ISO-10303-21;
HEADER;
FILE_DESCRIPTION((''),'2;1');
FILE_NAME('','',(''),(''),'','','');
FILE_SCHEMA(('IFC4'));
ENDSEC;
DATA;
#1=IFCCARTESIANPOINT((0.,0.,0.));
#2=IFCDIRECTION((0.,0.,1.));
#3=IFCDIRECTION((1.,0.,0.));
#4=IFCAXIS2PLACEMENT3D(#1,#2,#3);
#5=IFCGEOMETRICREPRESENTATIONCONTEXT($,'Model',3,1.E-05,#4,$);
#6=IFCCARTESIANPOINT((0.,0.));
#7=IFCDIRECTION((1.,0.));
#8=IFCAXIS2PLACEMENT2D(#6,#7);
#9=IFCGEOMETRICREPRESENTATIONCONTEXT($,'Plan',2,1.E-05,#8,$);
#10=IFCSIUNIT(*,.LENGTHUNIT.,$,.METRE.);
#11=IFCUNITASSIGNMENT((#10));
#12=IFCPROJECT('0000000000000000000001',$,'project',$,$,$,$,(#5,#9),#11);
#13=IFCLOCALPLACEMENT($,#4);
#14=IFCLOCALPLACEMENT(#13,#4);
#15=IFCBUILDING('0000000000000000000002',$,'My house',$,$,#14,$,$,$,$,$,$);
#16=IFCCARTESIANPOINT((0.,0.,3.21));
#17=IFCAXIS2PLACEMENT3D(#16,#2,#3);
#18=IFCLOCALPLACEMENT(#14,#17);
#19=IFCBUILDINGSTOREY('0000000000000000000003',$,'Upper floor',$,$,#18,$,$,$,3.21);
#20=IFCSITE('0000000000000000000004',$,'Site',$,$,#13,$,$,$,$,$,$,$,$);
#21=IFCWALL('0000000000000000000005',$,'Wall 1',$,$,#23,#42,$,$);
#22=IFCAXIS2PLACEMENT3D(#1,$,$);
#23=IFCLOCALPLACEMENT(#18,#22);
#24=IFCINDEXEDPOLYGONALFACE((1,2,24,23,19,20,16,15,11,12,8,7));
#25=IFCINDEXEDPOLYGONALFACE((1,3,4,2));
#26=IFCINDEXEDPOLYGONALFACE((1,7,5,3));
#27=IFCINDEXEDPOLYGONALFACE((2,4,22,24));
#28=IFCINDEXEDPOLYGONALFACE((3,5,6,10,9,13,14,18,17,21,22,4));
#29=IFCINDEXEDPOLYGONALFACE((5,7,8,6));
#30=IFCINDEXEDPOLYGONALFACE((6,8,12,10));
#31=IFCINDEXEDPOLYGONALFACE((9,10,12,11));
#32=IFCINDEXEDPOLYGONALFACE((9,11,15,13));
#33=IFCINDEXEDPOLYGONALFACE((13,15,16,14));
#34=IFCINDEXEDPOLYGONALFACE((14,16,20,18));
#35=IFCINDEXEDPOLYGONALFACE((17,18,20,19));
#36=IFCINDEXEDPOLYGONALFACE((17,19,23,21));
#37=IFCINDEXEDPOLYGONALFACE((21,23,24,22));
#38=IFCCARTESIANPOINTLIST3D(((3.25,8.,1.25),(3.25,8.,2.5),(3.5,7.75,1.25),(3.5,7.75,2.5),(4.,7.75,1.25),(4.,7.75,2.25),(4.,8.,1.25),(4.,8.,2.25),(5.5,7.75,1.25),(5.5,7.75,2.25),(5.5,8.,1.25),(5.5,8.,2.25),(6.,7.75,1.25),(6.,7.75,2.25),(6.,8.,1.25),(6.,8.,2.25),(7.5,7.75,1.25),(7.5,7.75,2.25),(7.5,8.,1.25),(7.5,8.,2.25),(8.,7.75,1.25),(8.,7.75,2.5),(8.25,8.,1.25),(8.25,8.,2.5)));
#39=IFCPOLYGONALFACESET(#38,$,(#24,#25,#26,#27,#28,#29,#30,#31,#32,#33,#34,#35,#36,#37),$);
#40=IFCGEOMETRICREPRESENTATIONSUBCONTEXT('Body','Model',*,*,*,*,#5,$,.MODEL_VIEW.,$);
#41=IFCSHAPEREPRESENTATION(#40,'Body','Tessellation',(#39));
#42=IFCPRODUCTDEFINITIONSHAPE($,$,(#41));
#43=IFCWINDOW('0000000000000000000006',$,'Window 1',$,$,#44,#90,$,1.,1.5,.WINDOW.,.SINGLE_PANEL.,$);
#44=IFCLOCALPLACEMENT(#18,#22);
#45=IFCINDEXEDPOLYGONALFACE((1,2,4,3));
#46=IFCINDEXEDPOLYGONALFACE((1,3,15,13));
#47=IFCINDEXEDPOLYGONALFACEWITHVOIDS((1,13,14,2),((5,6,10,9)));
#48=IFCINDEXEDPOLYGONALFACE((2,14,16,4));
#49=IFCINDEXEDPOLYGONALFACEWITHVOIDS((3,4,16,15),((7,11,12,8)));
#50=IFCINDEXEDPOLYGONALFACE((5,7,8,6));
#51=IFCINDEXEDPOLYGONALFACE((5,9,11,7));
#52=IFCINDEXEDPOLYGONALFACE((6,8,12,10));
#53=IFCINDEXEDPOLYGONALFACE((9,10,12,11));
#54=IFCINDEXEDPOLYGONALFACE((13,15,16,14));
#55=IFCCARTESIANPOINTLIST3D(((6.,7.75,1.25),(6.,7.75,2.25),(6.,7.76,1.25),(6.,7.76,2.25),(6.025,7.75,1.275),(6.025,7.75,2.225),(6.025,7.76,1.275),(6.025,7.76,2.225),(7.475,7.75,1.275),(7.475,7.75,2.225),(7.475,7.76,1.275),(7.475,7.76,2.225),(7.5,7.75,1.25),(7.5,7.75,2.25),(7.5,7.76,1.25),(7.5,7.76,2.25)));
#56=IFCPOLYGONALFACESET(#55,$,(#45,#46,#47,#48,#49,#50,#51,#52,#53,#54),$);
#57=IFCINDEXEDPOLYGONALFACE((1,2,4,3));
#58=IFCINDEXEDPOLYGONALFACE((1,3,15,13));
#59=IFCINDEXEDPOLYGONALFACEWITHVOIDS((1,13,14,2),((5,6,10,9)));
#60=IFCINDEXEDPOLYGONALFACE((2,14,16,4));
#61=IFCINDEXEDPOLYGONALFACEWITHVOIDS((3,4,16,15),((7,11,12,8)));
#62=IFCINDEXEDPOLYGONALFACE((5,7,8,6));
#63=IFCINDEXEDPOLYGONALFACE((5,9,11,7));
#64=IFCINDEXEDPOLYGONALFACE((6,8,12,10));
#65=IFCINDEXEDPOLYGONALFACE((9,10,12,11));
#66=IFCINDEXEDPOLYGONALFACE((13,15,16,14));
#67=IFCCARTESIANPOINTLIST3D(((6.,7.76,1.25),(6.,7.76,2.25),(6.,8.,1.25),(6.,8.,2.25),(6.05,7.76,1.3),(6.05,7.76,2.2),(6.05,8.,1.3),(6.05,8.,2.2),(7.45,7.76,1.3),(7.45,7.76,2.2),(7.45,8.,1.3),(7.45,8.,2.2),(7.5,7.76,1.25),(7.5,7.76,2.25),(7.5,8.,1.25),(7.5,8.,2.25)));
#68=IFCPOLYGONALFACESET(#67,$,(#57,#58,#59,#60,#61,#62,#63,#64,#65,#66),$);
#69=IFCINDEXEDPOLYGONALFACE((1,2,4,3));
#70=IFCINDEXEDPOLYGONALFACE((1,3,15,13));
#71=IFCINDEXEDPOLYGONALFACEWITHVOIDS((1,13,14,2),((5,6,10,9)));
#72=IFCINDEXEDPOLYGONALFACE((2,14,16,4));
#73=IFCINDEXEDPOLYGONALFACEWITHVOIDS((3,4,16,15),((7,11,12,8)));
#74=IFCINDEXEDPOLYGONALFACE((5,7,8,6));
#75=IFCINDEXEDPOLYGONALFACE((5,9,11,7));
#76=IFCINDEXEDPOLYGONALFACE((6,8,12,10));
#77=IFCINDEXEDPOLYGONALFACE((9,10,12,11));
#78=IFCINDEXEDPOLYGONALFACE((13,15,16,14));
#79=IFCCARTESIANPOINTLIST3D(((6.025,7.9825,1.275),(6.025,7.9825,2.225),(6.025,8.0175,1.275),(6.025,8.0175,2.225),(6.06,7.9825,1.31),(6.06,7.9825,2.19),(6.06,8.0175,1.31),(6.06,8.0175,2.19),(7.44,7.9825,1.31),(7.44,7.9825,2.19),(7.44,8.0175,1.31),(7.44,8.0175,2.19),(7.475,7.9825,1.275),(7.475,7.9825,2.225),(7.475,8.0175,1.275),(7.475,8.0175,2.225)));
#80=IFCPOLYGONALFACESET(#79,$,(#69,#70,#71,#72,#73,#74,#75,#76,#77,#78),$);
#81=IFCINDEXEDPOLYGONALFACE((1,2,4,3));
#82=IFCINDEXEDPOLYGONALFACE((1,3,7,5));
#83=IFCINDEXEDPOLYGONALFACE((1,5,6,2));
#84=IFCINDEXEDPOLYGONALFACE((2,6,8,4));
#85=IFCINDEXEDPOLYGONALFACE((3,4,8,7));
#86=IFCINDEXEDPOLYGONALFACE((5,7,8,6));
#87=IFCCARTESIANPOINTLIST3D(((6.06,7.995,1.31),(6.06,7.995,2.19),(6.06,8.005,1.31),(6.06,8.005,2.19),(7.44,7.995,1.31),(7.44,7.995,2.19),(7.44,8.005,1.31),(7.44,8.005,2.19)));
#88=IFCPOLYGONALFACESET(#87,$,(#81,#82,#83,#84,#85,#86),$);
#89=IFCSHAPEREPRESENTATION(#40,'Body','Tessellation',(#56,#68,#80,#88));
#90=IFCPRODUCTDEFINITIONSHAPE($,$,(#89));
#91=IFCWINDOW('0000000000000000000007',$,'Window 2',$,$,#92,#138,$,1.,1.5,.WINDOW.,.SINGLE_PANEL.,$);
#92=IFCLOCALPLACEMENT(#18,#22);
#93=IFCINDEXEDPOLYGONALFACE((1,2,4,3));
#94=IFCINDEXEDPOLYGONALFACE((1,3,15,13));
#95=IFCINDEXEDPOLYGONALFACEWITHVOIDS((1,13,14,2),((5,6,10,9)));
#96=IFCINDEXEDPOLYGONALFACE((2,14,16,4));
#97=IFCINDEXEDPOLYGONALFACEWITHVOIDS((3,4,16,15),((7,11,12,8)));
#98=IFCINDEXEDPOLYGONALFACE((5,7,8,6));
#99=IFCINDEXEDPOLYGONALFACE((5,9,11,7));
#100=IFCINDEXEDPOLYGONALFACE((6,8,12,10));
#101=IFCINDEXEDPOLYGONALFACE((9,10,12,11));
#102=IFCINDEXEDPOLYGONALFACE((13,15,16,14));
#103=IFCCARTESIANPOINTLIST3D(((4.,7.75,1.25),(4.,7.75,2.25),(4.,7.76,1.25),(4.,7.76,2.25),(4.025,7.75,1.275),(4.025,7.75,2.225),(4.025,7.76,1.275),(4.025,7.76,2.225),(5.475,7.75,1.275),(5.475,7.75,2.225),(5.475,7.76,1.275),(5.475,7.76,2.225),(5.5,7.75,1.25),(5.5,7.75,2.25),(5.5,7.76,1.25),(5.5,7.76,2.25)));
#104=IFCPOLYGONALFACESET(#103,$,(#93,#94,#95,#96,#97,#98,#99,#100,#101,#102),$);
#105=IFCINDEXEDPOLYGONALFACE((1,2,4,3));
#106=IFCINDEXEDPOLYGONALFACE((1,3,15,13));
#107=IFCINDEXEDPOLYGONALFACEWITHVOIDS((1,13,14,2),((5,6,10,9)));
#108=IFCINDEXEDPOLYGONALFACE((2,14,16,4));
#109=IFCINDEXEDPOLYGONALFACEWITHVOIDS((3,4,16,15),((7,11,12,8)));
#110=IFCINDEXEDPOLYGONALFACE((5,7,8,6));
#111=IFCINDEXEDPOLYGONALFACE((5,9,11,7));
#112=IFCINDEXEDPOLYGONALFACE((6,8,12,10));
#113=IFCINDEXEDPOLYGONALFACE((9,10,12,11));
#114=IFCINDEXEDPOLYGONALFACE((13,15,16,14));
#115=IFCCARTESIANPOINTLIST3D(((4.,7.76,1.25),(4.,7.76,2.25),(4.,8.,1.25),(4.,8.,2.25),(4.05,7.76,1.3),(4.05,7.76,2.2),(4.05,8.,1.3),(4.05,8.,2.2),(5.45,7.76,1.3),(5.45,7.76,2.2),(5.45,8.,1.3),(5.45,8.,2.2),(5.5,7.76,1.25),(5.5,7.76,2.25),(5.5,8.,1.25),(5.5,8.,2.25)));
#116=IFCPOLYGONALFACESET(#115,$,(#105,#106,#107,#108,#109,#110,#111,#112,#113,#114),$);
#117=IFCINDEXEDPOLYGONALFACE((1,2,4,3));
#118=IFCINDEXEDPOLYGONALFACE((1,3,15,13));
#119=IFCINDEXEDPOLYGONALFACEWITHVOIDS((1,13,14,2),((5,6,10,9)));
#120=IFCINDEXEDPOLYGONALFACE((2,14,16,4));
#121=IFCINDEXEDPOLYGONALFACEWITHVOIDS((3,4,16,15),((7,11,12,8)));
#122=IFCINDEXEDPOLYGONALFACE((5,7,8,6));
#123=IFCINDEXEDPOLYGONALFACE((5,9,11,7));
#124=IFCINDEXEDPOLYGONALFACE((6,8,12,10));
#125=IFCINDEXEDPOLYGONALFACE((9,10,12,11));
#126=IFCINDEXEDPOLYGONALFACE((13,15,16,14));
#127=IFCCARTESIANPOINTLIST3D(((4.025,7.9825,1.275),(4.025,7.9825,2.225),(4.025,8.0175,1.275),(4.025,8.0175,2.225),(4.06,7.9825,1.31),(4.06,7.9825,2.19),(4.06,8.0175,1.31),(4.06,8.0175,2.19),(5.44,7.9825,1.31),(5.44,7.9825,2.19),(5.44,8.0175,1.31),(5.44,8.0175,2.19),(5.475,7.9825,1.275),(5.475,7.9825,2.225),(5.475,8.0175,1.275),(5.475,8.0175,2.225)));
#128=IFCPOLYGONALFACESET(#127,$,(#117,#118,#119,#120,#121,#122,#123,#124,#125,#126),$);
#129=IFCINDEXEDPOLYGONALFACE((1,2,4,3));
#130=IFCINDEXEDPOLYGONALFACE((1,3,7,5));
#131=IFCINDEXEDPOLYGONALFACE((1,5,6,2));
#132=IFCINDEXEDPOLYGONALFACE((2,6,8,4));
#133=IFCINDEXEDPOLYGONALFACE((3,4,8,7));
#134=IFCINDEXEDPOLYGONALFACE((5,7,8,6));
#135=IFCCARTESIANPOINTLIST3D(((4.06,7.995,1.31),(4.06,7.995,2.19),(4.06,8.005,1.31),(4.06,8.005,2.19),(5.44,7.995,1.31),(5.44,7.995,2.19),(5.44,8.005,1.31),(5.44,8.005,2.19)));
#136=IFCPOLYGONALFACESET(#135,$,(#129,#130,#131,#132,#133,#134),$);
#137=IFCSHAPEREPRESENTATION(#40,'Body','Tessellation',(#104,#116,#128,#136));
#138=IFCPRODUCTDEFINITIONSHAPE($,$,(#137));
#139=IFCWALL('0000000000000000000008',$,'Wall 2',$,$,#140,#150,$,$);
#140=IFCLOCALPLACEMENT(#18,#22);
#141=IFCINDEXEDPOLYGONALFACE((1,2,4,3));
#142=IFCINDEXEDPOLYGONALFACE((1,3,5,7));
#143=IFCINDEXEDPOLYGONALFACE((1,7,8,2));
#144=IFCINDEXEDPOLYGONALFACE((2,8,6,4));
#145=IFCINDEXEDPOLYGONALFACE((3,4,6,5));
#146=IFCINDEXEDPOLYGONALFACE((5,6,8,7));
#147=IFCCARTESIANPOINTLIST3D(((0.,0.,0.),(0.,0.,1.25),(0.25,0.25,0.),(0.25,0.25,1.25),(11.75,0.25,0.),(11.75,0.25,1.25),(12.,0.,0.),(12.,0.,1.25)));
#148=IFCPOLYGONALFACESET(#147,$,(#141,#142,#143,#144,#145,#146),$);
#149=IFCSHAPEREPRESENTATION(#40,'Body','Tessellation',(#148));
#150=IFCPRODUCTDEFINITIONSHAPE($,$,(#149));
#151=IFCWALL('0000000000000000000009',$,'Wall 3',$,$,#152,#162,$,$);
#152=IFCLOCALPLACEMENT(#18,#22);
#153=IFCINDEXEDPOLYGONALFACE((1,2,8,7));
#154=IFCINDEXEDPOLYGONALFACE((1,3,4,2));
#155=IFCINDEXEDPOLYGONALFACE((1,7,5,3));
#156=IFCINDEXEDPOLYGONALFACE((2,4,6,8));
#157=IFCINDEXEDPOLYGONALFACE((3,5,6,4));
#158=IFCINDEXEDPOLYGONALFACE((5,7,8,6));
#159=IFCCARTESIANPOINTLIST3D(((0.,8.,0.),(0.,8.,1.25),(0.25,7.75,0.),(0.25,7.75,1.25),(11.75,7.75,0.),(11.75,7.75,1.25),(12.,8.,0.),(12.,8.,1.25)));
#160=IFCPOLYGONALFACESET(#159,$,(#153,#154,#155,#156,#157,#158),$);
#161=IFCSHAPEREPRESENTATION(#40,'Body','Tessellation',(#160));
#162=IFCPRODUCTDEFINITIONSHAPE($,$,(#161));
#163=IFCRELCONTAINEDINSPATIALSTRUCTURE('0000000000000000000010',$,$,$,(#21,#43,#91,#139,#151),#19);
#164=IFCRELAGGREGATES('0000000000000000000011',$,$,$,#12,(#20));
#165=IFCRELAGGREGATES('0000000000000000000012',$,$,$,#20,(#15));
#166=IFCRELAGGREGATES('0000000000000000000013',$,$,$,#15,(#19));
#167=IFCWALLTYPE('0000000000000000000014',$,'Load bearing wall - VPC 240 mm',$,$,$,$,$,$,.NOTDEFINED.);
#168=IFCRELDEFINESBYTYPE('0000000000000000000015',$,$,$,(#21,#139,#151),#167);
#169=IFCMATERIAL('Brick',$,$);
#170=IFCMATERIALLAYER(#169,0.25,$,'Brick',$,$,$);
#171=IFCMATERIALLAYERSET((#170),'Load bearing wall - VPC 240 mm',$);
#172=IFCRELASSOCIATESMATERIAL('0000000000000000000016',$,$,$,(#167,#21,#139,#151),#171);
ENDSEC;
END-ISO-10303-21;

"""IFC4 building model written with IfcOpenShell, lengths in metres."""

from ifc_helpers import new_model, entity, si_unit, frame, origin_with_axes, origin_2d_with_axis, place, context, subcontext, project, spatial, line, indexed_curve, outline, extrude, shape, material, layer, layer_set, layer_usage, type_object, element, fill, save


model = new_model("IFC4")

# Units and contexts
model_context = context("Model", 3, precision=1e-05, world=origin_with_axes())
plan_context = context("Plan", 2, precision=1e-05, world=origin_2d_with_axis())
body_context_1 = subcontext(model_context, "Body", "Model", "MODEL_VIEW")
body_context_2 = subcontext(plan_context, "Body", "Plan", "PLAN_VIEW")
ifc_project = project(units=[si_unit("LENGTHUNIT", "METRE")], contexts=[model_context, plan_context])

# Site, building, storey
site_placement = place(None, origin_with_axes())
site = spatial("IfcSite", under=ifc_project, at=site_placement, Name="Site")
building_placement = place(site_placement, origin_with_axes())
building = spatial("IfcBuilding", under=site, at=building_placement, Name="My house")
storey_placement = place(building_placement, frame((0.0, 0.0, 3.21), z_axis=(0.0, 0.0, 1.0), x_axis=(1.0, 0.0, 0.0)))
storey = spatial("IfcBuildingStorey", under=building, at=storey_placement, Name="Upper floor", Elevation=3.21)

# Wall, openings, windows
ifc_material_1 = material(Name="Brick")
ifc_layer_1 = layer(ifc_material_1, 0.25, Name="Brick")
ifc_layer_set_1 = layer_set([ifc_layer_1], Name="Load bearing wall - VPC 240 mm")
ifc_layer_usage_1 = layer_usage(ifc_layer_set_1, "AXIS2", "NEGATIVE", 0.25)
wall_type_1 = type_object("IfcWallType", Name="Load bearing wall - VPC 240 mm", PredefinedType="NOTDEFINED", material=ifc_layer_set_1)
wall_1_placement = place(storey_placement, frame((8.25, 8.0, 1.25), z_axis=(0.0, 0.0, 1.0), x_axis=(-1.0, 0.0, 0.0)))
wall_1 = element("IfcWall", 1, at=wall_1_placement, inside=storey, type_object=wall_type_1, material=ifc_layer_usage_1, Name="Wall 1", context=body_context_1, shape_type="SweptSolid", body=[
    extrude(outline(indexed_curve([(0.0, 0.0), (0.25, 0.25), (4.75, 0.25), (5.0, 0.0)], segments=[line(1, 2, 3, 4, 1)])), origin_with_axes(), (0.0, 0.0, 1.0), 1.25),
])
opening_1_placement = place(wall_1_placement, frame((0.75, 0.0, 0.0), z_axis=(0.0, 0.0, 1.0), x_axis=(1.0, 0.0, 0.0)))
opening_1 = element("IfcOpeningElement", 2, at=opening_1_placement, cuts=wall_1, PredefinedType="OPENING", context=body_context_1, shape_type="SweptSolid", body=[
    extrude(outline(indexed_curve([(0.0, 0.0), (0.0, 0.35), (1.5, 0.35), (1.5, 0.0), (0.0, 0.0)], self_intersect=False)), frame((0.0, -0.05, 0.0), z_axis=(0.0, 0.0, 1.0), x_axis=(1.0, 0.0, 0.0)), (0.0, 0.0, 1.0), 1.0),
])
opening_2_placement = place(wall_1_placement, frame((2.75, 0.0, 0.0), z_axis=(0.0, 0.0, 1.0), x_axis=(1.0, 0.0, 0.0)))
opening_2 = element("IfcOpeningElement", 3, at=opening_2_placement, cuts=wall_1, PredefinedType="OPENING", context=body_context_1, shape_type="SweptSolid", body=[
    extrude(outline(indexed_curve([(0.0, 0.0), (0.0, 0.35), (1.5, 0.35), (1.5, 0.0), (0.0, 0.0)], self_intersect=False)), frame((0.0, -0.05, 0.0), z_axis=(0.0, 0.0, 1.0), x_axis=(1.0, 0.0, 0.0)), (0.0, 0.0, 1.0), 1.0),
])
window_1_placement = place(opening_1_placement, frame((0.0, 0.0, 0.0), z_axis=(0.0, 0.0, 1.0), x_axis=(1.0, 0.0, 0.0)))
window_1 = element("IfcWindow", 4, at=window_1_placement, inside=storey, Name="Window 1", OverallHeight=1.0, OverallWidth=1.5, PartitioningType="SINGLE_PANEL", PredefinedType="WINDOW", shapes=[
    shape(body_context_1, "Body", "SweptSolid", [extrude(outline(indexed_curve([(0.0, 0.0), (1.5, 0.0), (1.5, 1.0), (0.0, 1.0)], segments=[line(1, 2, 3, 4, 1)]), holes=[indexed_curve([(0.025, 0.025), (1.475, 0.025), (1.475, 0.975), (0.025, 0.975)], segments=[line(1, 2, 3, 4, 1)])]), frame((0.0, 0.24, 0.0), z_axis=(0.0, -1.0, 0.0), x_axis=(1.0, 0.0, 0.0)), (0.0, 0.0, -1.0), 0.01), extrude(outline(indexed_curve([(0.0, 0.0), (1.5, 0.0), (1.5, 1.0), (0.0, 1.0)], segments=[line(1, 2, 3, 4, 1)]), holes=[indexed_curve([(0.05, 0.05), (1.45, 0.05), (1.45, 0.95), (0.05, 0.95)], segments=[line(1, 2, 3, 4, 1)])]), frame((0.0, 0.0, 0.0), z_axis=(0.0, -1.0, 0.0), x_axis=(1.0, 0.0, 0.0)), (0.0, 0.0, -1.0), 0.24), extrude(outline(indexed_curve([(0.0, 0.0), (1.45, 0.0), (1.45, 0.95), (0.0, 0.95)], segments=[line(1, 2, 3, 4, 1)]), holes=[indexed_curve([(0.035, 0.035), (1.415, 0.035), (1.415, 0.915), (0.035, 0.915)], segments=[line(1, 2, 3, 4, 1)])]), frame((0.025, -0.0175, 0.025), z_axis=(0.0, -1.0, 0.0), x_axis=(1.0, 0.0, 0.0)), (0.0, 0.0, -1.0), 0.035), extrude(outline(indexed_curve([(0.035, 0.035), (1.415, 0.035), (1.415, 0.915), (0.035, 0.915)], segments=[line(1, 2, 3, 4, 1)])), frame((0.025, -0.005, 0.025), z_axis=(0.0, -1.0, 0.0), x_axis=(1.0, 0.0, 0.0)), (0.0, 0.0, -1.0), 0.01)]),
    shape(body_context_2, "Body", "Curve2D", [entity("IfcIndexedPolyCurve", entity("IfcCartesianPointList2D", [[0.05, 0.0], [1.45, 0.0]])), entity("IfcIndexedPolyCurve", entity("IfcCartesianPointList2D", [[0.0, 0.25], [0.025, 0.25], [0.025, 0.24], [0.05, 0.24], [0.05, 0.0], [0.0, 0.0]]), [entity("IfcLineIndex", [1, 2, 3, 4, 5, 6, 1])]), entity("IfcIndexedPolyCurve", entity("IfcCartesianPointList2D", [[1.5, 0.25], [1.475, 0.25], [1.475, 0.24], [1.45, 0.24], [1.45, 0.0], [1.5, 0.0]]), [entity("IfcLineIndex", [1, 2, 3, 4, 5, 6, 1])]), entity("IfcIndexedPolyCurve", entity("IfcCartesianPointList2D", [[0.025, -0.0175], [0.06, -0.0175], [0.06, 0.0175], [0.025, 0.0175]]), [entity("IfcLineIndex", [1, 2, 3, 4, 1])]), entity("IfcIndexedPolyCurve", entity("IfcCartesianPointList2D", [[1.475, -0.0175], [1.44, -0.0175], [1.44, 0.0175], [1.475, 0.0175]]), [entity("IfcLineIndex", [1, 2, 3, 4, 1])]), entity("IfcIndexedPolyCurve", entity("IfcCartesianPointList2D", [[0.06, -0.0175], [1.44, -0.0175]])), entity("IfcIndexedPolyCurve", entity("IfcCartesianPointList2D", [[0.06, 0.0175], [1.44, 0.0175]])), entity("IfcIndexedPolyCurve", entity("IfcCartesianPointList2D", [[0.06, 0.0], [1.44, 0.0]]))]),
])
fill(opening_1, window_1)
window_2_placement = place(opening_2_placement, frame((0.0, 0.0, 0.0), z_axis=(0.0, 0.0, 1.0), x_axis=(1.0, 0.0, 0.0)))
window_2 = element("IfcWindow", 5, at=window_2_placement, inside=storey, Name="Window 2", OverallHeight=1.0, OverallWidth=1.5, PartitioningType="SINGLE_PANEL", PredefinedType="WINDOW", shapes=[
    shape(body_context_1, "Body", "SweptSolid", [extrude(outline(indexed_curve([(0.0, 0.0), (1.5, 0.0), (1.5, 1.0), (0.0, 1.0)], segments=[line(1, 2, 3, 4, 1)]), holes=[indexed_curve([(0.025, 0.025), (1.475, 0.025), (1.475, 0.975), (0.025, 0.975)], segments=[line(1, 2, 3, 4, 1)])]), frame((0.0, 0.24, 0.0), z_axis=(0.0, -1.0, 0.0), x_axis=(1.0, 0.0, 0.0)), (0.0, 0.0, -1.0), 0.01), extrude(outline(indexed_curve([(0.0, 0.0), (1.5, 0.0), (1.5, 1.0), (0.0, 1.0)], segments=[line(1, 2, 3, 4, 1)]), holes=[indexed_curve([(0.05, 0.05), (1.45, 0.05), (1.45, 0.95), (0.05, 0.95)], segments=[line(1, 2, 3, 4, 1)])]), frame((0.0, 0.0, 0.0), z_axis=(0.0, -1.0, 0.0), x_axis=(1.0, 0.0, 0.0)), (0.0, 0.0, -1.0), 0.24), extrude(outline(indexed_curve([(0.0, 0.0), (1.45, 0.0), (1.45, 0.95), (0.0, 0.95)], segments=[line(1, 2, 3, 4, 1)]), holes=[indexed_curve([(0.035, 0.035), (1.415, 0.035), (1.415, 0.915), (0.035, 0.915)], segments=[line(1, 2, 3, 4, 1)])]), frame((0.025, -0.0175, 0.025), z_axis=(0.0, -1.0, 0.0), x_axis=(1.0, 0.0, 0.0)), (0.0, 0.0, -1.0), 0.035), extrude(outline(indexed_curve([(0.035, 0.035), (1.415, 0.035), (1.415, 0.915), (0.035, 0.915)], segments=[line(1, 2, 3, 4, 1)])), frame((0.025, -0.005, 0.025), z_axis=(0.0, -1.0, 0.0), x_axis=(1.0, 0.0, 0.0)), (0.0, 0.0, -1.0), 0.01)]),
    shape(body_context_2, "Body", "Curve2D", [entity("IfcIndexedPolyCurve", entity("IfcCartesianPointList2D", [[0.05, 0.0], [1.45, 0.0]])), entity("IfcIndexedPolyCurve", entity("IfcCartesianPointList2D", [[0.0, 0.25], [0.025, 0.25], [0.025, 0.24], [0.05, 0.24], [0.05, 0.0], [0.0, 0.0]]), [entity("IfcLineIndex", [1, 2, 3, 4, 5, 6, 1])]), entity("IfcIndexedPolyCurve", entity("IfcCartesianPointList2D", [[1.5, 0.25], [1.475, 0.25], [1.475, 0.24], [1.45, 0.24], [1.45, 0.0], [1.5, 0.0]]), [entity("IfcLineIndex", [1, 2, 3, 4, 5, 6, 1])]), entity("IfcIndexedPolyCurve", entity("IfcCartesianPointList2D", [[0.025, -0.0175], [0.06, -0.0175], [0.06, 0.0175], [0.025, 0.0175]]), [entity("IfcLineIndex", [1, 2, 3, 4, 1])]), entity("IfcIndexedPolyCurve", entity("IfcCartesianPointList2D", [[1.475, -0.0175], [1.44, -0.0175], [1.44, 0.0175], [1.475, 0.0175]]), [entity("IfcLineIndex", [1, 2, 3, 4, 1])]), entity("IfcIndexedPolyCurve", entity("IfcCartesianPointList2D", [[0.06, -0.0175], [1.44, -0.0175]])), entity("IfcIndexedPolyCurve", entity("IfcCartesianPointList2D", [[0.06, 0.0175], [1.44, 0.0175]])), entity("IfcIndexedPolyCurve", entity("IfcCartesianPointList2D", [[0.06, 0.0], [1.44, 0.0]]))]),
])
fill(opening_2, window_2)

# Walls
ifc_layer_usage_2 = layer_usage(ifc_layer_set_1, "AXIS2", "NEGATIVE", 0.25)
wall_2_placement = place(storey_placement, origin_with_axes())
element("IfcWall", 6, at=wall_2_placement, inside=storey, type_object=wall_type_1, material=ifc_layer_usage_2, Name="Wall 2", context=body_context_1, shape_type="SweptSolid", body=[
    extrude(outline(indexed_curve([(0.0, 0.0), (0.25, 0.25), (11.75, 0.25), (12.0, 0.0)], segments=[line(1, 2, 3, 4, 1)])), origin_with_axes(), (0.0, 0.0, 1.0), 1.25),
])
ifc_layer_usage_3 = layer_usage(ifc_layer_set_1, "AXIS2", "NEGATIVE", 0.25)
wall_3_placement = place(storey_placement, frame((12.0, 8.0, 0.0), z_axis=(0.0, 0.0, 1.0), x_axis=(-1.0, 0.0, 0.0)))
element("IfcWall", 7, at=wall_3_placement, inside=storey, type_object=wall_type_1, material=ifc_layer_usage_3, Name="Wall 3", context=body_context_1, shape_type="SweptSolid", body=[
    extrude(outline(indexed_curve([(0.0, 0.0), (0.25, 0.25), (11.75, 0.25), (12.0, 0.0)], segments=[line(1, 2, 3, 4, 1)])), origin_with_axes(), (0.0, 0.0, 1.0), 1.25),
])

save(model, "model.ifc")
